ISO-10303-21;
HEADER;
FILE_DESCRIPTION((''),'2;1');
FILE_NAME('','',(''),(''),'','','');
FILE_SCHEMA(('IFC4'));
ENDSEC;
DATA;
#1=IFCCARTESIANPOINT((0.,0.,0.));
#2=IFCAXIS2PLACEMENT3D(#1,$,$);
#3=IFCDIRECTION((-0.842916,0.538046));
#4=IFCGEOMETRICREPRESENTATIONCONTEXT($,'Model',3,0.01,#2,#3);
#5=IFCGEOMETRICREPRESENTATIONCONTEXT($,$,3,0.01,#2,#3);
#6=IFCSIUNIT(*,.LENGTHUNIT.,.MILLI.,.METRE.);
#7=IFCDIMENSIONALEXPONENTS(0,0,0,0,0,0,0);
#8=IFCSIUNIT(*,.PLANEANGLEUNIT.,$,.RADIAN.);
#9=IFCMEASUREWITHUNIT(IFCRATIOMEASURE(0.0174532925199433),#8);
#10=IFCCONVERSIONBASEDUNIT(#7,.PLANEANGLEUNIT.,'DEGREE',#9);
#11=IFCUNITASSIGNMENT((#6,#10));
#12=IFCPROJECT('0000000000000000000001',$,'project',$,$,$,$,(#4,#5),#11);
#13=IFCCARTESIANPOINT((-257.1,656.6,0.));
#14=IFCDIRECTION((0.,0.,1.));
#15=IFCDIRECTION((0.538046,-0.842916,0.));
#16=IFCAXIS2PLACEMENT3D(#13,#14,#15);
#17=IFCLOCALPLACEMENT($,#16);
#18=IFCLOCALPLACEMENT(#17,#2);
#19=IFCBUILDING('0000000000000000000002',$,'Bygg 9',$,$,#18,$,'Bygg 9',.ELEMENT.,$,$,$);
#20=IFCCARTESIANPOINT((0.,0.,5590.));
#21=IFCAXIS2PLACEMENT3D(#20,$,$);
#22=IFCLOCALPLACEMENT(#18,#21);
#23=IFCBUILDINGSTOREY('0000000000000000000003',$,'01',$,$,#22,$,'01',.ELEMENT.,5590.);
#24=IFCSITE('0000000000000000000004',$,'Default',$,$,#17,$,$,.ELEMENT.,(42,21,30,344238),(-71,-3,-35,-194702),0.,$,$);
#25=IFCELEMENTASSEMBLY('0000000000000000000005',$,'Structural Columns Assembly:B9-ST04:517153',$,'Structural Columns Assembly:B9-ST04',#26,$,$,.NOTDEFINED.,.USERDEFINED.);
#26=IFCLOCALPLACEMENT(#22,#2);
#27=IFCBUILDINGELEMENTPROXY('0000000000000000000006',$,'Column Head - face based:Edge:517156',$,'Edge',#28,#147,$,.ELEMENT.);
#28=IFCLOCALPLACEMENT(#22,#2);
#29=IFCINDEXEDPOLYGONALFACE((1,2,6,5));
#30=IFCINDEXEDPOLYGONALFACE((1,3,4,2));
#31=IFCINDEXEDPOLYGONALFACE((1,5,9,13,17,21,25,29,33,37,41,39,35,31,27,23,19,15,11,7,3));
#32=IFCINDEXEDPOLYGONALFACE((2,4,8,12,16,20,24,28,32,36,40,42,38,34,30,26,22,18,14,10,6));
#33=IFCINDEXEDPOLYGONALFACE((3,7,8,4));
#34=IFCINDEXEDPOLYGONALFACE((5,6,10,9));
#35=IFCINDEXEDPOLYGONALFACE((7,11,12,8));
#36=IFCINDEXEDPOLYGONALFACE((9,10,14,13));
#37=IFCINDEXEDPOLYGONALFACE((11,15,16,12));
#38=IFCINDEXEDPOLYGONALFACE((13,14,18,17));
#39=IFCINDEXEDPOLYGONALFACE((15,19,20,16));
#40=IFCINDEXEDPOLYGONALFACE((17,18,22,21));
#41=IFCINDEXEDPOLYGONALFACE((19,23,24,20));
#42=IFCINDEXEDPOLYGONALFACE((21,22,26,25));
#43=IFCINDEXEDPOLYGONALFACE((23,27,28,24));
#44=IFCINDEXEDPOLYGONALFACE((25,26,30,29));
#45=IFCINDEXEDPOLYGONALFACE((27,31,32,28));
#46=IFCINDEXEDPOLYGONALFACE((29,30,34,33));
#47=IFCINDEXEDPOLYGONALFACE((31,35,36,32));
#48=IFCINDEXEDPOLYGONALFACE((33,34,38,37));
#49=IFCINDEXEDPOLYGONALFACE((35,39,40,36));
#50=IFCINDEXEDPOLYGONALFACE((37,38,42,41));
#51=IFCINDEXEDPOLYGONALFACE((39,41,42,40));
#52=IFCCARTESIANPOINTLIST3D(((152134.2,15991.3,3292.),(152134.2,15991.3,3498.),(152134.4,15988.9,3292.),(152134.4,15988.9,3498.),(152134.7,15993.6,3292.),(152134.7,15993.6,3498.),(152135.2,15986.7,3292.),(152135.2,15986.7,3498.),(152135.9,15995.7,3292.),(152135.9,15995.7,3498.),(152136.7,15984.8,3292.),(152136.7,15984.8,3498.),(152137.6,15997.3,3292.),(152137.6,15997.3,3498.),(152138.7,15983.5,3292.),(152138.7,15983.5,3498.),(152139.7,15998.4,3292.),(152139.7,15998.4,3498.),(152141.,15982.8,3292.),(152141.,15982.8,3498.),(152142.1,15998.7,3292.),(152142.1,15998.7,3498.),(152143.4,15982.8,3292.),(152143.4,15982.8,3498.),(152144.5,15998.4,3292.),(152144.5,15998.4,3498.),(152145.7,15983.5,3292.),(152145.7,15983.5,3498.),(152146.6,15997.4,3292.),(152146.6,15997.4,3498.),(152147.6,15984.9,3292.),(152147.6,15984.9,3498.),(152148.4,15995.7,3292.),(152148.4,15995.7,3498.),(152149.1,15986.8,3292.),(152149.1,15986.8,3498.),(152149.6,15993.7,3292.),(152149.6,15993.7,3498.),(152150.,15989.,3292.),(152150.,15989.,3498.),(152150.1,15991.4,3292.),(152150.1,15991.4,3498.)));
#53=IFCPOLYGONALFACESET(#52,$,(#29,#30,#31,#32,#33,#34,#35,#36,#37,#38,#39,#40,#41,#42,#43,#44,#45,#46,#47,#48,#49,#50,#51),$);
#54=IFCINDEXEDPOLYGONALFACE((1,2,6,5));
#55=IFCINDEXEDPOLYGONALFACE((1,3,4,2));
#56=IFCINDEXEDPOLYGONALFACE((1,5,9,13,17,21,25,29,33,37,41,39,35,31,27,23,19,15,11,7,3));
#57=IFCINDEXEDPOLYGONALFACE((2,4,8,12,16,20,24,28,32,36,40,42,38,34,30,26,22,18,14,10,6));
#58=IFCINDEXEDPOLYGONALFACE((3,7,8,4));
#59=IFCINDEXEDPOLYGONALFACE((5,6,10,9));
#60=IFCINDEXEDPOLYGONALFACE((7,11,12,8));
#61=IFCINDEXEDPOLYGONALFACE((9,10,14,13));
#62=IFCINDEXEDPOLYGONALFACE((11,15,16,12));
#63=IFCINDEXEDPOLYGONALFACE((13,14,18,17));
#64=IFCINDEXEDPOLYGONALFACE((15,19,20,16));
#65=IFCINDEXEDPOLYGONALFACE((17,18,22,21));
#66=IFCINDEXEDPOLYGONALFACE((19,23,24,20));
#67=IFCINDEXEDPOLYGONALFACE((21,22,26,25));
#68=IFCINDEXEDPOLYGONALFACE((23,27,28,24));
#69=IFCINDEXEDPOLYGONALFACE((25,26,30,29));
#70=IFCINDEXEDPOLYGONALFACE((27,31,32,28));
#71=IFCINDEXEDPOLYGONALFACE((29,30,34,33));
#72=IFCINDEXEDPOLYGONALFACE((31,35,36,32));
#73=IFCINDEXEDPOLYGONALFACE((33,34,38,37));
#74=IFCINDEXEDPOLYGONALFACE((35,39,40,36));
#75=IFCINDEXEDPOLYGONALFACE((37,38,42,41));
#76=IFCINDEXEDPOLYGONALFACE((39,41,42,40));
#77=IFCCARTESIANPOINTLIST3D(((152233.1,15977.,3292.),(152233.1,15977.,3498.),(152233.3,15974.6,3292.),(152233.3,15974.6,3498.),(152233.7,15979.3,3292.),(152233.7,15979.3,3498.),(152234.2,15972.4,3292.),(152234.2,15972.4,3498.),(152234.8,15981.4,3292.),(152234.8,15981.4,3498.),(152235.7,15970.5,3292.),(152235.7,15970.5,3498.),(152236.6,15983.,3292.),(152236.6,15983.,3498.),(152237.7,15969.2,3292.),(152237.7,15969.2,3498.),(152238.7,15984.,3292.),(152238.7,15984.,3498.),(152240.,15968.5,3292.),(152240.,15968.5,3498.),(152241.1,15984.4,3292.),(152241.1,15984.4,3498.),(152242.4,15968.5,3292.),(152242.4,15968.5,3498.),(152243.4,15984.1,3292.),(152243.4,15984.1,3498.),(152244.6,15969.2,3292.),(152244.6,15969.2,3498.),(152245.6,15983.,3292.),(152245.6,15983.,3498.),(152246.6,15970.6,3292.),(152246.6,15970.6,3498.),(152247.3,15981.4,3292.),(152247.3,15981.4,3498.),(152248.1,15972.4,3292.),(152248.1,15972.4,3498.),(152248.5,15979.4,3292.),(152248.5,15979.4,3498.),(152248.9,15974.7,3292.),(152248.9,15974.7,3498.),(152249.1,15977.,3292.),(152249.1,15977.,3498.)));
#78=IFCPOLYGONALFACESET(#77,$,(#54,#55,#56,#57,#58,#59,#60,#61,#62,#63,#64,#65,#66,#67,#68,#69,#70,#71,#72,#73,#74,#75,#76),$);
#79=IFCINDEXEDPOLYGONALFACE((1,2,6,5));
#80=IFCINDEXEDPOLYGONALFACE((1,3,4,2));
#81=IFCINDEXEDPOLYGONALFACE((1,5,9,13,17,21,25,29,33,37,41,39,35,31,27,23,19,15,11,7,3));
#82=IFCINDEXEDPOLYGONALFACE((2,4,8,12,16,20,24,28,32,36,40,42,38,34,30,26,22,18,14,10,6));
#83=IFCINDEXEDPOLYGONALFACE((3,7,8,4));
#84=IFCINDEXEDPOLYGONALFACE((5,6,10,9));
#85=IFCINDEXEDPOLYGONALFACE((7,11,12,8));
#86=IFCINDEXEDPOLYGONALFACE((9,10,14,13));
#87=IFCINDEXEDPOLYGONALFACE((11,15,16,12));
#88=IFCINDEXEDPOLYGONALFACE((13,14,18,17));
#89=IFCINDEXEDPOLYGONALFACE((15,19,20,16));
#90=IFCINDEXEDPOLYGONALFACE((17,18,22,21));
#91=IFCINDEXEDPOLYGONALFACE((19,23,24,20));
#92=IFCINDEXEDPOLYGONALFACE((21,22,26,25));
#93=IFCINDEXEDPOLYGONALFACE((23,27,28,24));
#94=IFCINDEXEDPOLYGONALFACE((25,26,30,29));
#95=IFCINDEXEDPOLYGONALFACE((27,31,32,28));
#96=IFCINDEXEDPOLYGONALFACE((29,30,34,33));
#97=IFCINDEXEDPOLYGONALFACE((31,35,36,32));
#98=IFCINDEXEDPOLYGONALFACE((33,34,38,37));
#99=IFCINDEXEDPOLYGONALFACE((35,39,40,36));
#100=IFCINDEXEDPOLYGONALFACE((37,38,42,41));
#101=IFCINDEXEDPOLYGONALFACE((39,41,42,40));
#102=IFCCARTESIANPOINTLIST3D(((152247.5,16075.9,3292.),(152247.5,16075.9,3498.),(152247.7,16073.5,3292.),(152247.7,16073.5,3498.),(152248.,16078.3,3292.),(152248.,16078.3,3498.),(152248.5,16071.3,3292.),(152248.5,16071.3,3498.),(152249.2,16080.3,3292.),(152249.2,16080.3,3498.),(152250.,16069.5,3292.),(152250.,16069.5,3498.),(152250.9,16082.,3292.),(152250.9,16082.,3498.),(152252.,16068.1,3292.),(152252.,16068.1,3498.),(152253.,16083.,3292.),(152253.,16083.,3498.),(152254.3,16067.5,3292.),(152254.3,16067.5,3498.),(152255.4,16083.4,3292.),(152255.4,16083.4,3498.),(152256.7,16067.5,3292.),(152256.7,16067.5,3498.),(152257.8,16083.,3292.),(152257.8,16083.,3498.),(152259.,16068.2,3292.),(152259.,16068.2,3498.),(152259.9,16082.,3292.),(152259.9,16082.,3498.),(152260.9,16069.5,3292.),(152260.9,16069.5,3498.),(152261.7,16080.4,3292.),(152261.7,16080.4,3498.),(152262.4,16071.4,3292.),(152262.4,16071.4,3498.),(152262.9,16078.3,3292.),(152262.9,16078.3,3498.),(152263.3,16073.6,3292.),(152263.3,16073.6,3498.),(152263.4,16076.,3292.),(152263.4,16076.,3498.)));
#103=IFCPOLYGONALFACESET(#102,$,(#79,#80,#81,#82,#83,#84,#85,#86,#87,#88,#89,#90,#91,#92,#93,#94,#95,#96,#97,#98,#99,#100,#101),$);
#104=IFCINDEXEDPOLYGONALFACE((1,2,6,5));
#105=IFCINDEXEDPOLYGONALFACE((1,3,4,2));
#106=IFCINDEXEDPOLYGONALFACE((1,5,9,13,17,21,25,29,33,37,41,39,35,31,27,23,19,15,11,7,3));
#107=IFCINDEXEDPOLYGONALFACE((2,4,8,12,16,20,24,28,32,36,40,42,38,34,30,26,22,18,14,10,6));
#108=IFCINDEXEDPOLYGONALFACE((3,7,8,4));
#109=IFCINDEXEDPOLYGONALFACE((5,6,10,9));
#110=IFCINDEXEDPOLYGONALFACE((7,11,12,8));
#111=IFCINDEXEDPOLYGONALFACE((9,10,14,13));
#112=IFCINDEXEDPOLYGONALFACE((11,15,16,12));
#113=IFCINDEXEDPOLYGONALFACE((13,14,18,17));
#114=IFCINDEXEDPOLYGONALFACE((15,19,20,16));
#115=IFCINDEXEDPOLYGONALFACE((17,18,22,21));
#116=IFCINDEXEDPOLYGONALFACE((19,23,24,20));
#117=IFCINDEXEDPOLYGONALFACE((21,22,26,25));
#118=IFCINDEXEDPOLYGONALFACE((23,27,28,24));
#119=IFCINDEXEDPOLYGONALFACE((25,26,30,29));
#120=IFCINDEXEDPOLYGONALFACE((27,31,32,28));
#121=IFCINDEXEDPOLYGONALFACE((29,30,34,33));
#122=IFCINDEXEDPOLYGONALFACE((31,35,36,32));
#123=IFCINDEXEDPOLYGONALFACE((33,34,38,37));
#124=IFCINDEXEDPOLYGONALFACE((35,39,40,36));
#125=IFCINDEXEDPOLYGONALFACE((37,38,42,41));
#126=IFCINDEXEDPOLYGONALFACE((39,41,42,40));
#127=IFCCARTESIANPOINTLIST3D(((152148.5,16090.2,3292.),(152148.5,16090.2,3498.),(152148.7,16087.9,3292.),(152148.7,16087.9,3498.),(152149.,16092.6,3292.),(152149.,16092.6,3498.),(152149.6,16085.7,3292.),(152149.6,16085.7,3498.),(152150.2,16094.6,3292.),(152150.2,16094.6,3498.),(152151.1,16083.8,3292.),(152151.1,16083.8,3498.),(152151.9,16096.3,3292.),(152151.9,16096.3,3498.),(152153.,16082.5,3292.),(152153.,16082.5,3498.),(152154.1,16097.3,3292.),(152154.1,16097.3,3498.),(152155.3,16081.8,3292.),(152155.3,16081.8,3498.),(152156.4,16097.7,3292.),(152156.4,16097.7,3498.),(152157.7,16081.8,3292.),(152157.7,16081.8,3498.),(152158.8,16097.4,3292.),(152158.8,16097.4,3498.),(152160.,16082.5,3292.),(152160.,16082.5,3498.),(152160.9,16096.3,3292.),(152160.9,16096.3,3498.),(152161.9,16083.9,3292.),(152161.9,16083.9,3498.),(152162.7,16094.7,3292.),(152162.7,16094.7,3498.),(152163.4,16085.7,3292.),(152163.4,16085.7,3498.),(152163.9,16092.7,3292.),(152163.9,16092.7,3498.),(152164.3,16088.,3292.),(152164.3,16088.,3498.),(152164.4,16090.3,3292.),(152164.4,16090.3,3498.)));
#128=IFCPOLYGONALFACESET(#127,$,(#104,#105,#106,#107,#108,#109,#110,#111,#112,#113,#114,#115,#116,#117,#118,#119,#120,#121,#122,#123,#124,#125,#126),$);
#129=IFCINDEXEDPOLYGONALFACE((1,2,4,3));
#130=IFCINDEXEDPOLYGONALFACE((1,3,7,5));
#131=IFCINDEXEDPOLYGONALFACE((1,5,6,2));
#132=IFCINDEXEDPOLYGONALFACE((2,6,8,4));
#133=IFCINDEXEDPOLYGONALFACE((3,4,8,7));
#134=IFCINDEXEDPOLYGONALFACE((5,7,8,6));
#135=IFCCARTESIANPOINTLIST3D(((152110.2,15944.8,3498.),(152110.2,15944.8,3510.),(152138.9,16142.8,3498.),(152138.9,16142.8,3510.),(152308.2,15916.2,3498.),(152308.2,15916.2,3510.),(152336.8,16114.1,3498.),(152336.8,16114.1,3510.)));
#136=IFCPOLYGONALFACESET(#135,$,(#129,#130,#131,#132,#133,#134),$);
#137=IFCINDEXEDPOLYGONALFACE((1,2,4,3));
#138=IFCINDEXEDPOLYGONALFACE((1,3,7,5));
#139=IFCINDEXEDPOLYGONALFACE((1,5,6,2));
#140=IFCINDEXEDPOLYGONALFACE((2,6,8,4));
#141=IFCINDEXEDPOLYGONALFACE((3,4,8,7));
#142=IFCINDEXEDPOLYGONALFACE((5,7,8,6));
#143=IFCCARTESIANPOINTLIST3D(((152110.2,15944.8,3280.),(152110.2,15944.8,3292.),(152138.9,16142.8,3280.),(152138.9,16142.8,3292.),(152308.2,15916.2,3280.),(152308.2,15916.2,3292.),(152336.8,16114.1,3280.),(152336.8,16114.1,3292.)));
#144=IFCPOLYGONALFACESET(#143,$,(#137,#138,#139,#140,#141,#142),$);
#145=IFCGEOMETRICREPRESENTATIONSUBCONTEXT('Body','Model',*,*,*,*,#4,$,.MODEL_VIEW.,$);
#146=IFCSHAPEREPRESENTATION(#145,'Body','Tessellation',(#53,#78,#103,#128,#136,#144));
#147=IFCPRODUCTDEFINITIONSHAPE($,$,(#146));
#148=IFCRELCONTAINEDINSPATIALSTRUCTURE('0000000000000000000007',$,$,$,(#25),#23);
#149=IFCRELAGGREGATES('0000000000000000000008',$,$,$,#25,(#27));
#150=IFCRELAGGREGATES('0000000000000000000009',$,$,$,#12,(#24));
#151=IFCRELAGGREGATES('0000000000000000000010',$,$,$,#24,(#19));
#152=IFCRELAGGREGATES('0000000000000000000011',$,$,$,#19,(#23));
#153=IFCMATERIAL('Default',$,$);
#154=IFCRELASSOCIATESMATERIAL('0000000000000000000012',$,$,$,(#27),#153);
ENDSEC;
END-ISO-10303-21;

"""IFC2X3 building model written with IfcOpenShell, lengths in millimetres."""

from ifc_helpers import new_model, entity, si_unit, converted_unit, direction, frame, frame_2d, origin, origin_2d_with_axis, place, context, subcontext, project, spatial, rectangle, circle, extrude, source, transform, mapped, material, element, aggregate, save


model = new_model("IFC2X3")

# Units and contexts
model_context = context("Model", 3, precision=0.01, world=origin(), true_north=direction((-0.842916, 0.538046)))
context_of_model = context(None, 3, precision=0.01, world=origin(), true_north=direction((-0.842916, 0.538046)))
body_context = subcontext(model_context, "Body", "Model", "MODEL_VIEW")
ifc_project = project(units=[si_unit("LENGTHUNIT", "METRE", prefix="MILLI"), converted_unit("PLANEANGLEUNIT", "DEGREE", entity("IfcRatioMeasure", 0.0174532925199433), si_unit("PLANEANGLEUNIT", "RADIAN"), dimensions=[0, 0, 0, 0, 0, 0, 0])], contexts=[model_context, context_of_model])

# Site, building, storey
site_placement = place(None, frame((-257.1, 656.6, 0.0), z_axis=(0.0, 0.0, 1.0), x_axis=(0.538046, -0.842916, 0.0)))
site = spatial("IfcSite", under=ifc_project, at=site_placement, Name="Default", CompositionType="ELEMENT", RefLatitude=(42, 21, 30, 344238), RefLongitude=(-71, -3, -35, -194702), RefElevation=0.0)
building_placement = place(site_placement, origin())
building = spatial("IfcBuilding", under=site, at=building_placement, Name="Bygg 9", LongName="Bygg 9", CompositionType="ELEMENT")
storey_placement = place(building_placement, frame((0.0, 0.0, 5590.0)))
storey = spatial("IfcBuildingStorey", under=building, at=storey_placement, Name="01", LongName="01", CompositionType="ELEMENT", Elevation=5590.0)

# Element assembly
assembly_1_placement = place(storey_placement, origin())
assembly_1 = element("IfcElementAssembly", 1, at=assembly_1_placement, inside=storey, Name="Structural Columns Assembly:B9-ST04:517153", ObjectType="Structural Columns Assembly:B9-ST04", AssemblyPlace="NOTDEFINED", PredefinedType="USERDEFINED")

# Building element proxy
ifc_material_1 = material(Name="Default")
shared_shape_1 = source(origin(), body_context, "Body", "SweptSolid", [
    extrude(circle(Radius=8.0, at=frame_2d((0.0, 0.0), x_axis=(1.0, 0.0))), frame((50.0, -75.0, 12.0)), (0.0, 0.0, 1.0), 206.0),
    extrude(circle(Radius=8.0, at=frame_2d((0.0, 0.0), x_axis=(1.0, 0.0))), frame((50.0, 25.0, 12.0)), (0.0, 0.0, 1.0), 206.0),
    extrude(circle(Radius=8.0, at=frame_2d((0.0, 0.0), x_axis=(1.0, 0.0))), frame((-50.0, 25.0, 12.0)), (0.0, 0.0, 1.0), 206.0),
    extrude(circle(Radius=8.0, at=frame_2d((0.0, 0.0), x_axis=(1.0, 0.0))), frame((-50.0, -75.0, 12.0)), (0.0, 0.0, 1.0), 206.0),
    extrude(rectangle(XDim=200.0, YDim=200.0, at=origin_2d_with_axis()), frame((0.0, 0.0, 218.0), z_axis=(0.0, 0.0, 1.0), x_axis=(-1.0, 0.0, 0.0)), (0.0, 0.0, 1.0), 12.0),
    extrude(rectangle(XDim=200.0, YDim=200.0, at=origin_2d_with_axis()), frame((0.0, 0.0, 0.0), z_axis=(0.0, 0.0, 1.0), x_axis=(0.0, 1.0, 0.0)), (0.0, 0.0, 1.0), 12.0),
])
proxy_1_placement = place(assembly_1_placement, frame((152223.5, 16029.5, 3280.0), z_axis=(0.0, 0.0, 1.0), x_axis=(-0.143216, -0.989691, 0.0)))
proxy_1 = element("IfcBuildingElementProxy", 2, at=proxy_1_placement, material=ifc_material_1, Name="Column Head - face based:Edge:517156", ObjectType="Edge", CompositionType="ELEMENT", context=body_context, shape_type="MappedRepresentation", body=[
    mapped(shared_shape_1, transform((0.0, 0.0, 0.0), scale=1.0)),
])
aggregate(assembly_1, [proxy_1])

save(model, "model.ifc")
